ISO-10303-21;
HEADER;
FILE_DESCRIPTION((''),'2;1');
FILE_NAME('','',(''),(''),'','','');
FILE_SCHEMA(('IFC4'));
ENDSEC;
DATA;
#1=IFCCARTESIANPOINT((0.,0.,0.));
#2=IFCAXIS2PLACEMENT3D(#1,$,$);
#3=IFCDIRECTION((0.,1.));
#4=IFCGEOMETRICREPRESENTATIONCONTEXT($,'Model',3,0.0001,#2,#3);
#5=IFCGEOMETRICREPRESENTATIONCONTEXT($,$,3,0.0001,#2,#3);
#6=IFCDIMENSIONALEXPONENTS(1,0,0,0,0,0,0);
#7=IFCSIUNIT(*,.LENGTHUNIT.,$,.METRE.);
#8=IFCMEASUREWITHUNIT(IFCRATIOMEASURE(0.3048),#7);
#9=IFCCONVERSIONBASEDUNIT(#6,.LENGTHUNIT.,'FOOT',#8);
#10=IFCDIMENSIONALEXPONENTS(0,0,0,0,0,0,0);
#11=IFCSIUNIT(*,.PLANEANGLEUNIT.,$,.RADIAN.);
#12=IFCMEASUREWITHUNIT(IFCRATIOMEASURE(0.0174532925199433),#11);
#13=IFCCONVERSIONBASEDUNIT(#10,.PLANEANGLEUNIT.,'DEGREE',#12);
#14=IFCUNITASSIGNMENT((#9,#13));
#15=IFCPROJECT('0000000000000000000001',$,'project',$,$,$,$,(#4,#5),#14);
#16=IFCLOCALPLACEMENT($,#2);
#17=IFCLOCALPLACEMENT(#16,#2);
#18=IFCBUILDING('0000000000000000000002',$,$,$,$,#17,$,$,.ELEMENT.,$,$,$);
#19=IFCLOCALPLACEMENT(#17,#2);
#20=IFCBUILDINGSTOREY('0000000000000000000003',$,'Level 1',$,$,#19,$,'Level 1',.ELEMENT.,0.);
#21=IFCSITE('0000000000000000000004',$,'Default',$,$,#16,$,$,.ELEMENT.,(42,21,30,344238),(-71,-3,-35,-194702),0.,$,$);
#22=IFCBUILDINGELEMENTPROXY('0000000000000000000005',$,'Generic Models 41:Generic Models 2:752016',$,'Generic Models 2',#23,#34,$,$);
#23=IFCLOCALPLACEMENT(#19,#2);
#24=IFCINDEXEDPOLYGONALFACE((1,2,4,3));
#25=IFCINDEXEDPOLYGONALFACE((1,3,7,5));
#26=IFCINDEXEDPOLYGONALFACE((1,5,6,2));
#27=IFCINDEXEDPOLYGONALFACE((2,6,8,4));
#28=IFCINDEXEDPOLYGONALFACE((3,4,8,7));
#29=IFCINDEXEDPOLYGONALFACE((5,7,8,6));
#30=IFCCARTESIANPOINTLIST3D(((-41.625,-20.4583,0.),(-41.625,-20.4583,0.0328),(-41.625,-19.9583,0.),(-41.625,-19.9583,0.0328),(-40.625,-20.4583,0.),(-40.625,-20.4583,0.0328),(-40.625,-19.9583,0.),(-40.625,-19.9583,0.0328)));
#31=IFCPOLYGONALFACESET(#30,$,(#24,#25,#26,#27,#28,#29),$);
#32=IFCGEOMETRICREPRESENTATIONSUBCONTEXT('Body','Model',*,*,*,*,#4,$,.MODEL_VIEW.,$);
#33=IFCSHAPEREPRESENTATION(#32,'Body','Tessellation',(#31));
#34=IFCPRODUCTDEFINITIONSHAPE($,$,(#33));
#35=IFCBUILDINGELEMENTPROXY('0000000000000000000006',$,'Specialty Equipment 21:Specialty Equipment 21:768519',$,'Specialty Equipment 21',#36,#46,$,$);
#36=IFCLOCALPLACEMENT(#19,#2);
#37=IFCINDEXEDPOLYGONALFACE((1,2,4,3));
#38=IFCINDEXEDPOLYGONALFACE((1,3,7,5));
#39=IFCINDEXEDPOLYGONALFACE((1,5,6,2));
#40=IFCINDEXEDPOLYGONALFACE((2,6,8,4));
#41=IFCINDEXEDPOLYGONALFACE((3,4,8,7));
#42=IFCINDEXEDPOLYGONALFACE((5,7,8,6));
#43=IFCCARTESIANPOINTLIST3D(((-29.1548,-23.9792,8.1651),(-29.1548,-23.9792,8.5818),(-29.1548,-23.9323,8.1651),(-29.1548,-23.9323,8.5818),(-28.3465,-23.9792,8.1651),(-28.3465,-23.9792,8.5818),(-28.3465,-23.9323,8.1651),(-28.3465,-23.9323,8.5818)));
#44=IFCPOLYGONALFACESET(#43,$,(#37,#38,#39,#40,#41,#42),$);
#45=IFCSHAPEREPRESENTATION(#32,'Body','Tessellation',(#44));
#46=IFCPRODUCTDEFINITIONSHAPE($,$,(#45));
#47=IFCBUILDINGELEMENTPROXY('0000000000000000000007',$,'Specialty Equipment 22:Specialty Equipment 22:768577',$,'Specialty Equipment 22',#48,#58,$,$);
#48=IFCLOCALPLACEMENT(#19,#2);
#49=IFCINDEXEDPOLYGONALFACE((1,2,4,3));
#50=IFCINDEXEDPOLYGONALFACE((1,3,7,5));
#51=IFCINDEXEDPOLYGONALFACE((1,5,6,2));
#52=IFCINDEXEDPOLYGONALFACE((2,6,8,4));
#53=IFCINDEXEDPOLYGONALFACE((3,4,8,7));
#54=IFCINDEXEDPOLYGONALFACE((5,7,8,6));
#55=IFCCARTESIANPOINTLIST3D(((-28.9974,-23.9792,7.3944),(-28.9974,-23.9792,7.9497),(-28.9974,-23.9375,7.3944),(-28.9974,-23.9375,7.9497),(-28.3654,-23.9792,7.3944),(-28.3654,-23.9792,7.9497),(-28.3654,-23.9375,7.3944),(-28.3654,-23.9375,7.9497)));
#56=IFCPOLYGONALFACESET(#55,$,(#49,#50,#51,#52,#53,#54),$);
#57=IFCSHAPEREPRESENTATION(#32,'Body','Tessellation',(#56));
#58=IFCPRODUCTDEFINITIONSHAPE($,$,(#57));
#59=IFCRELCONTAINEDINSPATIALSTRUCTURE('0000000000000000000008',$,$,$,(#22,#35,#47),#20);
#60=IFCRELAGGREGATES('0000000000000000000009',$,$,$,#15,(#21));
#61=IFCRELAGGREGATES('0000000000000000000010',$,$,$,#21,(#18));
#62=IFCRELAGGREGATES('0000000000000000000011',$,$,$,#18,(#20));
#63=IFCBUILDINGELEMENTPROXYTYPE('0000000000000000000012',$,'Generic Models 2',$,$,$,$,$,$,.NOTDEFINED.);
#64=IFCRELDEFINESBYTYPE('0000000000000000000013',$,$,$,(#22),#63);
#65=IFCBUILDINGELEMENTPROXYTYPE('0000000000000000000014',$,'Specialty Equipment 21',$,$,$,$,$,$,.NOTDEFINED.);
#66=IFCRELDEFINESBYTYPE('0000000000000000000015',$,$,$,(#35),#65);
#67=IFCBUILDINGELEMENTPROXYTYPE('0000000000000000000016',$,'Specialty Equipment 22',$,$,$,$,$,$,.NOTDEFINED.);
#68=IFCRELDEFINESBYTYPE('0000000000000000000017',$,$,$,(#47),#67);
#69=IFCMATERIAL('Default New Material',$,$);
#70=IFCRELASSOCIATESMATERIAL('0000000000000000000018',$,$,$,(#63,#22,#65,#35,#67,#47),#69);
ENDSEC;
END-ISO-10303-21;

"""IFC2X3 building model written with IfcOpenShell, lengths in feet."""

from ifc_helpers import new_model, entity, si_unit, converted_unit, direction, frame, frame_2d, origin, origin_2d_with_axis, place, context, subcontext, project, spatial, rectangle, extrude, source, transform, mapped, material, type_object, type_shapes, element, save


model = new_model("IFC2X3")

# Units and contexts
model_context = context("Model", 3, precision=0.0001, world=origin(), true_north=direction((0.0, 1.0)))
context_of_model = context(None, 3, precision=0.0001, world=origin(), true_north=direction((0.0, 1.0)))
body_context = subcontext(model_context, "Body", "Model", "MODEL_VIEW")
ifc_project = project(units=[converted_unit("LENGTHUNIT", "FOOT", entity("IfcRatioMeasure", 0.3048), si_unit("LENGTHUNIT", "METRE"), dimensions=[1, 0, 0, 0, 0, 0, 0]), converted_unit("PLANEANGLEUNIT", "DEGREE", entity("IfcRatioMeasure", 0.0174532925199433), si_unit("PLANEANGLEUNIT", "RADIAN"), dimensions=[0, 0, 0, 0, 0, 0, 0])], contexts=[model_context, context_of_model])

# Site, building, storey
site_placement = place(None, origin())
site = spatial("IfcSite", under=ifc_project, at=site_placement, Name="Default", CompositionType="ELEMENT", RefLatitude=(42, 21, 30, 344238), RefLongitude=(-71, -3, -35, -194702), RefElevation=0.0)
building_placement = place(site_placement, origin())
building = spatial("IfcBuilding", under=site, at=building_placement, CompositionType="ELEMENT")
storey_placement = place(building_placement, origin())
storey = spatial("IfcBuildingStorey", under=building, at=storey_placement, Name="Level 1", LongName="Level 1", CompositionType="ELEMENT", Elevation=0.0)

# Shared definitions
ifc_material_1 = material(Name="Default New Material")

# Building element proxies
building_element_proxy_type_1 = type_object("IfcBuildingElementProxyType", Name="Generic Models 2", PredefinedType="NOTDEFINED", material=ifc_material_1)
shared_shape_1 = source(origin(), body_context, "Body", "SweptSolid", [
    extrude(rectangle(XDim=1.0, YDim=0.5, at=origin_2d_with_axis()), frame((0.5, 0.25, 0.0), z_axis=(0.0, 0.0, 1.0), x_axis=(-1.0, 0.0, 0.0)), (0.0, 0.0, 1.0), 0.0328),
])
type_shapes(building_element_proxy_type_1, [shared_shape_1])
proxy_1_placement = place(storey_placement, frame((-41.625, -20.4583, 0.0)))
element("IfcBuildingElementProxy", 1, at=proxy_1_placement, inside=storey, type_object=building_element_proxy_type_1, material=ifc_material_1, Name="Generic Models 41:Generic Models 2:752016", ObjectType="Generic Models 2", context=body_context, shape_type="MappedRepresentation", body=[
    mapped(shared_shape_1, transform((0.0, 0.0, 0.0), scale=1.0)),
])
building_element_proxy_type_2 = type_object("IfcBuildingElementProxyType", Name="Specialty Equipment 21", PredefinedType="NOTDEFINED", material=ifc_material_1)
shared_shape_2 = source(origin(), body_context, "Body", "SweptSolid", [
    extrude(rectangle(XDim=0.0468, YDim=0.8083, at=frame_2d((0.0, 0.0), x_axis=(1.0, 0.0))), frame((0.4041, 0.0234, 0.0), z_axis=(0.0, 0.0, 1.0), x_axis=(0.0, -1.0, 0.0)), (0.0, 0.0, 1.0), 0.4167),
])
type_shapes(building_element_proxy_type_2, [shared_shape_2])
proxy_2_placement = place(storey_placement, frame((-29.1548, -23.9792, 8.1651)))
element("IfcBuildingElementProxy", 2, at=proxy_2_placement, inside=storey, type_object=building_element_proxy_type_2, material=ifc_material_1, Name="Specialty Equipment 21:Specialty Equipment 21:768519", ObjectType="Specialty Equipment 21", context=body_context, shape_type="MappedRepresentation", body=[
    mapped(shared_shape_2, transform((0.0, 0.0, 0.0), scale=1.0)),
])
building_element_proxy_type_3 = type_object("IfcBuildingElementProxyType", Name="Specialty Equipment 22", PredefinedType="NOTDEFINED", material=ifc_material_1)
shared_shape_3 = source(origin(), body_context, "Body", "SweptSolid", [
    extrude(rectangle(XDim=0.0417, YDim=0.632, at=frame_2d((0.0, 0.0), x_axis=(1.0, 0.0))), frame((0.316, 0.0208, 0.0), z_axis=(0.0, 0.0, 1.0), x_axis=(0.0, -1.0, 0.0)), (0.0, 0.0, 1.0), 0.5553),
])
type_shapes(building_element_proxy_type_3, [shared_shape_3])
proxy_3_placement = place(storey_placement, frame((-28.9974, -23.9792, 7.3944)))
element("IfcBuildingElementProxy", 3, at=proxy_3_placement, inside=storey, type_object=building_element_proxy_type_3, material=ifc_material_1, Name="Specialty Equipment 22:Specialty Equipment 22:768577", ObjectType="Specialty Equipment 22", context=body_context, shape_type="MappedRepresentation", body=[
    mapped(shared_shape_3, transform((0.0, 0.0, 0.0), scale=1.0)),
])

save(model, "model.ifc")
